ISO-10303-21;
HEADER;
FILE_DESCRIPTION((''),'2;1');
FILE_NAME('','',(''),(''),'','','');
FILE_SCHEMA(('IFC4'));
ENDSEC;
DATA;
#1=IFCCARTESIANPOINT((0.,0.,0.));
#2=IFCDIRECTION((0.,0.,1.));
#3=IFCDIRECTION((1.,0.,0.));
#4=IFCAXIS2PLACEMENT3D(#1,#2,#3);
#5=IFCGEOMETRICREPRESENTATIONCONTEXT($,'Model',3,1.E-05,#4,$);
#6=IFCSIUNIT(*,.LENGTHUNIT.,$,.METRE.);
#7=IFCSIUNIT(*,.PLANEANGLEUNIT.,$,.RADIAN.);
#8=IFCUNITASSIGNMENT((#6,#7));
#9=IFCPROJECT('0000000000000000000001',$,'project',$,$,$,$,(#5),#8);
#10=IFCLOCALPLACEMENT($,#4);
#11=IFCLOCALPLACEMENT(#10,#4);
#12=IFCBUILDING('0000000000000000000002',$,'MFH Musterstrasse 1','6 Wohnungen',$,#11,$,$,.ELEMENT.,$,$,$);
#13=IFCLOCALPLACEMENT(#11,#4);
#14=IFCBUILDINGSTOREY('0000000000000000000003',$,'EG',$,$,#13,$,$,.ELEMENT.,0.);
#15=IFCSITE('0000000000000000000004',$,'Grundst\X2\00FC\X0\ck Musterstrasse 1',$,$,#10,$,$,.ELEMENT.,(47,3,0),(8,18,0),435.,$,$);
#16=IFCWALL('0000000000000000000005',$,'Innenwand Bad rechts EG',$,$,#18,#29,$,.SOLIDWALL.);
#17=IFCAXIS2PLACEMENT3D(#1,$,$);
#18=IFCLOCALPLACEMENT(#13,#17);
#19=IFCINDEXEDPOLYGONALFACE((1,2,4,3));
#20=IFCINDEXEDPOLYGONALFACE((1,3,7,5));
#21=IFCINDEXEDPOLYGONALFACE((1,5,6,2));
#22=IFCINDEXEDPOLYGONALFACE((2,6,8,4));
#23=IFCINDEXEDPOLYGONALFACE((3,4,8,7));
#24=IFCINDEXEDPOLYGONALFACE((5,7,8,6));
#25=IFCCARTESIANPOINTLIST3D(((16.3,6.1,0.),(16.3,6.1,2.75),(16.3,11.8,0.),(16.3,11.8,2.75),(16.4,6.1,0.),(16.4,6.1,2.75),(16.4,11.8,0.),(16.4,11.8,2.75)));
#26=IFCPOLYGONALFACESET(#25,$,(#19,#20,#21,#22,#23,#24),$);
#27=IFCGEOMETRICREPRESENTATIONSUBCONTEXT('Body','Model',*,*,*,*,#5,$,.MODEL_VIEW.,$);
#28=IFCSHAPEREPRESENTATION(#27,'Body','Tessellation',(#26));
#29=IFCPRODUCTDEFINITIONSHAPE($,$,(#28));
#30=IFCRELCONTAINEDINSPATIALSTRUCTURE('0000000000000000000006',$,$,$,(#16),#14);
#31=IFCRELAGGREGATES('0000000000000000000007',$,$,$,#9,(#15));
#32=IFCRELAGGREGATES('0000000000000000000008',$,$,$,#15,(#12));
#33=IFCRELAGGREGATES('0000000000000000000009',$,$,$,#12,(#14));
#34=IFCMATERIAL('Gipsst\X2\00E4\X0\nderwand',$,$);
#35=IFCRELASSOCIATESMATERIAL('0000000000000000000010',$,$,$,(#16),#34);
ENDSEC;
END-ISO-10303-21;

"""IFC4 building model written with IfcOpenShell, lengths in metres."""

from ifc_helpers import new_model, si_unit, frame, frame_2d, origin_with_axes, place, context, subcontext, project, spatial, rectangle, extrude, material, element, save


model = new_model("IFC4")

# Units and contexts
model_context = context("Model", 3, precision=1e-05, world=origin_with_axes())
body_context = subcontext(model_context, "Body", "Model", "MODEL_VIEW")
ifc_project = project(units=[si_unit("LENGTHUNIT", "METRE"), si_unit("PLANEANGLEUNIT", "RADIAN")], contexts=[model_context])

# Site, building, storey
site_placement = place(None, origin_with_axes())
site = spatial("IfcSite", under=ifc_project, at=site_placement, Name="Grundstück Musterstrasse 1", CompositionType="ELEMENT", RefLatitude=(47, 3, 0), RefLongitude=(8, 18, 0), RefElevation=435.0)
building_placement = place(site_placement, origin_with_axes())
building = spatial("IfcBuilding", under=site, at=building_placement, Name="MFH Musterstrasse 1", Description="6 Wohnungen", CompositionType="ELEMENT")
storey_placement = place(building_placement, origin_with_axes())
storey = spatial("IfcBuildingStorey", under=building, at=storey_placement, Name="EG", CompositionType="ELEMENT", Elevation=0.0)

# Shared definitions
ifc_material_1 = material(Name="Gipsständerwand")

# Wall
wall_1_placement = place(storey_placement, origin_with_axes())
element("IfcWall", 1, at=wall_1_placement, inside=storey, material=ifc_material_1, Name="Innenwand Bad rechts EG", PredefinedType="SOLIDWALL", context=body_context, shape_type="SweptSolid", body=[
    extrude(rectangle(XDim=0.1, YDim=5.7, at=frame_2d((0.05, 2.85), x_axis=(1.0, 0.0))), frame((16.3, 6.1, 0.0), z_axis=(0.0, 0.0, 1.0), x_axis=(1.0, 0.0, 0.0)), (0.0, 0.0, 1.0), 2.75),
])

save(model, "model.ifc")
